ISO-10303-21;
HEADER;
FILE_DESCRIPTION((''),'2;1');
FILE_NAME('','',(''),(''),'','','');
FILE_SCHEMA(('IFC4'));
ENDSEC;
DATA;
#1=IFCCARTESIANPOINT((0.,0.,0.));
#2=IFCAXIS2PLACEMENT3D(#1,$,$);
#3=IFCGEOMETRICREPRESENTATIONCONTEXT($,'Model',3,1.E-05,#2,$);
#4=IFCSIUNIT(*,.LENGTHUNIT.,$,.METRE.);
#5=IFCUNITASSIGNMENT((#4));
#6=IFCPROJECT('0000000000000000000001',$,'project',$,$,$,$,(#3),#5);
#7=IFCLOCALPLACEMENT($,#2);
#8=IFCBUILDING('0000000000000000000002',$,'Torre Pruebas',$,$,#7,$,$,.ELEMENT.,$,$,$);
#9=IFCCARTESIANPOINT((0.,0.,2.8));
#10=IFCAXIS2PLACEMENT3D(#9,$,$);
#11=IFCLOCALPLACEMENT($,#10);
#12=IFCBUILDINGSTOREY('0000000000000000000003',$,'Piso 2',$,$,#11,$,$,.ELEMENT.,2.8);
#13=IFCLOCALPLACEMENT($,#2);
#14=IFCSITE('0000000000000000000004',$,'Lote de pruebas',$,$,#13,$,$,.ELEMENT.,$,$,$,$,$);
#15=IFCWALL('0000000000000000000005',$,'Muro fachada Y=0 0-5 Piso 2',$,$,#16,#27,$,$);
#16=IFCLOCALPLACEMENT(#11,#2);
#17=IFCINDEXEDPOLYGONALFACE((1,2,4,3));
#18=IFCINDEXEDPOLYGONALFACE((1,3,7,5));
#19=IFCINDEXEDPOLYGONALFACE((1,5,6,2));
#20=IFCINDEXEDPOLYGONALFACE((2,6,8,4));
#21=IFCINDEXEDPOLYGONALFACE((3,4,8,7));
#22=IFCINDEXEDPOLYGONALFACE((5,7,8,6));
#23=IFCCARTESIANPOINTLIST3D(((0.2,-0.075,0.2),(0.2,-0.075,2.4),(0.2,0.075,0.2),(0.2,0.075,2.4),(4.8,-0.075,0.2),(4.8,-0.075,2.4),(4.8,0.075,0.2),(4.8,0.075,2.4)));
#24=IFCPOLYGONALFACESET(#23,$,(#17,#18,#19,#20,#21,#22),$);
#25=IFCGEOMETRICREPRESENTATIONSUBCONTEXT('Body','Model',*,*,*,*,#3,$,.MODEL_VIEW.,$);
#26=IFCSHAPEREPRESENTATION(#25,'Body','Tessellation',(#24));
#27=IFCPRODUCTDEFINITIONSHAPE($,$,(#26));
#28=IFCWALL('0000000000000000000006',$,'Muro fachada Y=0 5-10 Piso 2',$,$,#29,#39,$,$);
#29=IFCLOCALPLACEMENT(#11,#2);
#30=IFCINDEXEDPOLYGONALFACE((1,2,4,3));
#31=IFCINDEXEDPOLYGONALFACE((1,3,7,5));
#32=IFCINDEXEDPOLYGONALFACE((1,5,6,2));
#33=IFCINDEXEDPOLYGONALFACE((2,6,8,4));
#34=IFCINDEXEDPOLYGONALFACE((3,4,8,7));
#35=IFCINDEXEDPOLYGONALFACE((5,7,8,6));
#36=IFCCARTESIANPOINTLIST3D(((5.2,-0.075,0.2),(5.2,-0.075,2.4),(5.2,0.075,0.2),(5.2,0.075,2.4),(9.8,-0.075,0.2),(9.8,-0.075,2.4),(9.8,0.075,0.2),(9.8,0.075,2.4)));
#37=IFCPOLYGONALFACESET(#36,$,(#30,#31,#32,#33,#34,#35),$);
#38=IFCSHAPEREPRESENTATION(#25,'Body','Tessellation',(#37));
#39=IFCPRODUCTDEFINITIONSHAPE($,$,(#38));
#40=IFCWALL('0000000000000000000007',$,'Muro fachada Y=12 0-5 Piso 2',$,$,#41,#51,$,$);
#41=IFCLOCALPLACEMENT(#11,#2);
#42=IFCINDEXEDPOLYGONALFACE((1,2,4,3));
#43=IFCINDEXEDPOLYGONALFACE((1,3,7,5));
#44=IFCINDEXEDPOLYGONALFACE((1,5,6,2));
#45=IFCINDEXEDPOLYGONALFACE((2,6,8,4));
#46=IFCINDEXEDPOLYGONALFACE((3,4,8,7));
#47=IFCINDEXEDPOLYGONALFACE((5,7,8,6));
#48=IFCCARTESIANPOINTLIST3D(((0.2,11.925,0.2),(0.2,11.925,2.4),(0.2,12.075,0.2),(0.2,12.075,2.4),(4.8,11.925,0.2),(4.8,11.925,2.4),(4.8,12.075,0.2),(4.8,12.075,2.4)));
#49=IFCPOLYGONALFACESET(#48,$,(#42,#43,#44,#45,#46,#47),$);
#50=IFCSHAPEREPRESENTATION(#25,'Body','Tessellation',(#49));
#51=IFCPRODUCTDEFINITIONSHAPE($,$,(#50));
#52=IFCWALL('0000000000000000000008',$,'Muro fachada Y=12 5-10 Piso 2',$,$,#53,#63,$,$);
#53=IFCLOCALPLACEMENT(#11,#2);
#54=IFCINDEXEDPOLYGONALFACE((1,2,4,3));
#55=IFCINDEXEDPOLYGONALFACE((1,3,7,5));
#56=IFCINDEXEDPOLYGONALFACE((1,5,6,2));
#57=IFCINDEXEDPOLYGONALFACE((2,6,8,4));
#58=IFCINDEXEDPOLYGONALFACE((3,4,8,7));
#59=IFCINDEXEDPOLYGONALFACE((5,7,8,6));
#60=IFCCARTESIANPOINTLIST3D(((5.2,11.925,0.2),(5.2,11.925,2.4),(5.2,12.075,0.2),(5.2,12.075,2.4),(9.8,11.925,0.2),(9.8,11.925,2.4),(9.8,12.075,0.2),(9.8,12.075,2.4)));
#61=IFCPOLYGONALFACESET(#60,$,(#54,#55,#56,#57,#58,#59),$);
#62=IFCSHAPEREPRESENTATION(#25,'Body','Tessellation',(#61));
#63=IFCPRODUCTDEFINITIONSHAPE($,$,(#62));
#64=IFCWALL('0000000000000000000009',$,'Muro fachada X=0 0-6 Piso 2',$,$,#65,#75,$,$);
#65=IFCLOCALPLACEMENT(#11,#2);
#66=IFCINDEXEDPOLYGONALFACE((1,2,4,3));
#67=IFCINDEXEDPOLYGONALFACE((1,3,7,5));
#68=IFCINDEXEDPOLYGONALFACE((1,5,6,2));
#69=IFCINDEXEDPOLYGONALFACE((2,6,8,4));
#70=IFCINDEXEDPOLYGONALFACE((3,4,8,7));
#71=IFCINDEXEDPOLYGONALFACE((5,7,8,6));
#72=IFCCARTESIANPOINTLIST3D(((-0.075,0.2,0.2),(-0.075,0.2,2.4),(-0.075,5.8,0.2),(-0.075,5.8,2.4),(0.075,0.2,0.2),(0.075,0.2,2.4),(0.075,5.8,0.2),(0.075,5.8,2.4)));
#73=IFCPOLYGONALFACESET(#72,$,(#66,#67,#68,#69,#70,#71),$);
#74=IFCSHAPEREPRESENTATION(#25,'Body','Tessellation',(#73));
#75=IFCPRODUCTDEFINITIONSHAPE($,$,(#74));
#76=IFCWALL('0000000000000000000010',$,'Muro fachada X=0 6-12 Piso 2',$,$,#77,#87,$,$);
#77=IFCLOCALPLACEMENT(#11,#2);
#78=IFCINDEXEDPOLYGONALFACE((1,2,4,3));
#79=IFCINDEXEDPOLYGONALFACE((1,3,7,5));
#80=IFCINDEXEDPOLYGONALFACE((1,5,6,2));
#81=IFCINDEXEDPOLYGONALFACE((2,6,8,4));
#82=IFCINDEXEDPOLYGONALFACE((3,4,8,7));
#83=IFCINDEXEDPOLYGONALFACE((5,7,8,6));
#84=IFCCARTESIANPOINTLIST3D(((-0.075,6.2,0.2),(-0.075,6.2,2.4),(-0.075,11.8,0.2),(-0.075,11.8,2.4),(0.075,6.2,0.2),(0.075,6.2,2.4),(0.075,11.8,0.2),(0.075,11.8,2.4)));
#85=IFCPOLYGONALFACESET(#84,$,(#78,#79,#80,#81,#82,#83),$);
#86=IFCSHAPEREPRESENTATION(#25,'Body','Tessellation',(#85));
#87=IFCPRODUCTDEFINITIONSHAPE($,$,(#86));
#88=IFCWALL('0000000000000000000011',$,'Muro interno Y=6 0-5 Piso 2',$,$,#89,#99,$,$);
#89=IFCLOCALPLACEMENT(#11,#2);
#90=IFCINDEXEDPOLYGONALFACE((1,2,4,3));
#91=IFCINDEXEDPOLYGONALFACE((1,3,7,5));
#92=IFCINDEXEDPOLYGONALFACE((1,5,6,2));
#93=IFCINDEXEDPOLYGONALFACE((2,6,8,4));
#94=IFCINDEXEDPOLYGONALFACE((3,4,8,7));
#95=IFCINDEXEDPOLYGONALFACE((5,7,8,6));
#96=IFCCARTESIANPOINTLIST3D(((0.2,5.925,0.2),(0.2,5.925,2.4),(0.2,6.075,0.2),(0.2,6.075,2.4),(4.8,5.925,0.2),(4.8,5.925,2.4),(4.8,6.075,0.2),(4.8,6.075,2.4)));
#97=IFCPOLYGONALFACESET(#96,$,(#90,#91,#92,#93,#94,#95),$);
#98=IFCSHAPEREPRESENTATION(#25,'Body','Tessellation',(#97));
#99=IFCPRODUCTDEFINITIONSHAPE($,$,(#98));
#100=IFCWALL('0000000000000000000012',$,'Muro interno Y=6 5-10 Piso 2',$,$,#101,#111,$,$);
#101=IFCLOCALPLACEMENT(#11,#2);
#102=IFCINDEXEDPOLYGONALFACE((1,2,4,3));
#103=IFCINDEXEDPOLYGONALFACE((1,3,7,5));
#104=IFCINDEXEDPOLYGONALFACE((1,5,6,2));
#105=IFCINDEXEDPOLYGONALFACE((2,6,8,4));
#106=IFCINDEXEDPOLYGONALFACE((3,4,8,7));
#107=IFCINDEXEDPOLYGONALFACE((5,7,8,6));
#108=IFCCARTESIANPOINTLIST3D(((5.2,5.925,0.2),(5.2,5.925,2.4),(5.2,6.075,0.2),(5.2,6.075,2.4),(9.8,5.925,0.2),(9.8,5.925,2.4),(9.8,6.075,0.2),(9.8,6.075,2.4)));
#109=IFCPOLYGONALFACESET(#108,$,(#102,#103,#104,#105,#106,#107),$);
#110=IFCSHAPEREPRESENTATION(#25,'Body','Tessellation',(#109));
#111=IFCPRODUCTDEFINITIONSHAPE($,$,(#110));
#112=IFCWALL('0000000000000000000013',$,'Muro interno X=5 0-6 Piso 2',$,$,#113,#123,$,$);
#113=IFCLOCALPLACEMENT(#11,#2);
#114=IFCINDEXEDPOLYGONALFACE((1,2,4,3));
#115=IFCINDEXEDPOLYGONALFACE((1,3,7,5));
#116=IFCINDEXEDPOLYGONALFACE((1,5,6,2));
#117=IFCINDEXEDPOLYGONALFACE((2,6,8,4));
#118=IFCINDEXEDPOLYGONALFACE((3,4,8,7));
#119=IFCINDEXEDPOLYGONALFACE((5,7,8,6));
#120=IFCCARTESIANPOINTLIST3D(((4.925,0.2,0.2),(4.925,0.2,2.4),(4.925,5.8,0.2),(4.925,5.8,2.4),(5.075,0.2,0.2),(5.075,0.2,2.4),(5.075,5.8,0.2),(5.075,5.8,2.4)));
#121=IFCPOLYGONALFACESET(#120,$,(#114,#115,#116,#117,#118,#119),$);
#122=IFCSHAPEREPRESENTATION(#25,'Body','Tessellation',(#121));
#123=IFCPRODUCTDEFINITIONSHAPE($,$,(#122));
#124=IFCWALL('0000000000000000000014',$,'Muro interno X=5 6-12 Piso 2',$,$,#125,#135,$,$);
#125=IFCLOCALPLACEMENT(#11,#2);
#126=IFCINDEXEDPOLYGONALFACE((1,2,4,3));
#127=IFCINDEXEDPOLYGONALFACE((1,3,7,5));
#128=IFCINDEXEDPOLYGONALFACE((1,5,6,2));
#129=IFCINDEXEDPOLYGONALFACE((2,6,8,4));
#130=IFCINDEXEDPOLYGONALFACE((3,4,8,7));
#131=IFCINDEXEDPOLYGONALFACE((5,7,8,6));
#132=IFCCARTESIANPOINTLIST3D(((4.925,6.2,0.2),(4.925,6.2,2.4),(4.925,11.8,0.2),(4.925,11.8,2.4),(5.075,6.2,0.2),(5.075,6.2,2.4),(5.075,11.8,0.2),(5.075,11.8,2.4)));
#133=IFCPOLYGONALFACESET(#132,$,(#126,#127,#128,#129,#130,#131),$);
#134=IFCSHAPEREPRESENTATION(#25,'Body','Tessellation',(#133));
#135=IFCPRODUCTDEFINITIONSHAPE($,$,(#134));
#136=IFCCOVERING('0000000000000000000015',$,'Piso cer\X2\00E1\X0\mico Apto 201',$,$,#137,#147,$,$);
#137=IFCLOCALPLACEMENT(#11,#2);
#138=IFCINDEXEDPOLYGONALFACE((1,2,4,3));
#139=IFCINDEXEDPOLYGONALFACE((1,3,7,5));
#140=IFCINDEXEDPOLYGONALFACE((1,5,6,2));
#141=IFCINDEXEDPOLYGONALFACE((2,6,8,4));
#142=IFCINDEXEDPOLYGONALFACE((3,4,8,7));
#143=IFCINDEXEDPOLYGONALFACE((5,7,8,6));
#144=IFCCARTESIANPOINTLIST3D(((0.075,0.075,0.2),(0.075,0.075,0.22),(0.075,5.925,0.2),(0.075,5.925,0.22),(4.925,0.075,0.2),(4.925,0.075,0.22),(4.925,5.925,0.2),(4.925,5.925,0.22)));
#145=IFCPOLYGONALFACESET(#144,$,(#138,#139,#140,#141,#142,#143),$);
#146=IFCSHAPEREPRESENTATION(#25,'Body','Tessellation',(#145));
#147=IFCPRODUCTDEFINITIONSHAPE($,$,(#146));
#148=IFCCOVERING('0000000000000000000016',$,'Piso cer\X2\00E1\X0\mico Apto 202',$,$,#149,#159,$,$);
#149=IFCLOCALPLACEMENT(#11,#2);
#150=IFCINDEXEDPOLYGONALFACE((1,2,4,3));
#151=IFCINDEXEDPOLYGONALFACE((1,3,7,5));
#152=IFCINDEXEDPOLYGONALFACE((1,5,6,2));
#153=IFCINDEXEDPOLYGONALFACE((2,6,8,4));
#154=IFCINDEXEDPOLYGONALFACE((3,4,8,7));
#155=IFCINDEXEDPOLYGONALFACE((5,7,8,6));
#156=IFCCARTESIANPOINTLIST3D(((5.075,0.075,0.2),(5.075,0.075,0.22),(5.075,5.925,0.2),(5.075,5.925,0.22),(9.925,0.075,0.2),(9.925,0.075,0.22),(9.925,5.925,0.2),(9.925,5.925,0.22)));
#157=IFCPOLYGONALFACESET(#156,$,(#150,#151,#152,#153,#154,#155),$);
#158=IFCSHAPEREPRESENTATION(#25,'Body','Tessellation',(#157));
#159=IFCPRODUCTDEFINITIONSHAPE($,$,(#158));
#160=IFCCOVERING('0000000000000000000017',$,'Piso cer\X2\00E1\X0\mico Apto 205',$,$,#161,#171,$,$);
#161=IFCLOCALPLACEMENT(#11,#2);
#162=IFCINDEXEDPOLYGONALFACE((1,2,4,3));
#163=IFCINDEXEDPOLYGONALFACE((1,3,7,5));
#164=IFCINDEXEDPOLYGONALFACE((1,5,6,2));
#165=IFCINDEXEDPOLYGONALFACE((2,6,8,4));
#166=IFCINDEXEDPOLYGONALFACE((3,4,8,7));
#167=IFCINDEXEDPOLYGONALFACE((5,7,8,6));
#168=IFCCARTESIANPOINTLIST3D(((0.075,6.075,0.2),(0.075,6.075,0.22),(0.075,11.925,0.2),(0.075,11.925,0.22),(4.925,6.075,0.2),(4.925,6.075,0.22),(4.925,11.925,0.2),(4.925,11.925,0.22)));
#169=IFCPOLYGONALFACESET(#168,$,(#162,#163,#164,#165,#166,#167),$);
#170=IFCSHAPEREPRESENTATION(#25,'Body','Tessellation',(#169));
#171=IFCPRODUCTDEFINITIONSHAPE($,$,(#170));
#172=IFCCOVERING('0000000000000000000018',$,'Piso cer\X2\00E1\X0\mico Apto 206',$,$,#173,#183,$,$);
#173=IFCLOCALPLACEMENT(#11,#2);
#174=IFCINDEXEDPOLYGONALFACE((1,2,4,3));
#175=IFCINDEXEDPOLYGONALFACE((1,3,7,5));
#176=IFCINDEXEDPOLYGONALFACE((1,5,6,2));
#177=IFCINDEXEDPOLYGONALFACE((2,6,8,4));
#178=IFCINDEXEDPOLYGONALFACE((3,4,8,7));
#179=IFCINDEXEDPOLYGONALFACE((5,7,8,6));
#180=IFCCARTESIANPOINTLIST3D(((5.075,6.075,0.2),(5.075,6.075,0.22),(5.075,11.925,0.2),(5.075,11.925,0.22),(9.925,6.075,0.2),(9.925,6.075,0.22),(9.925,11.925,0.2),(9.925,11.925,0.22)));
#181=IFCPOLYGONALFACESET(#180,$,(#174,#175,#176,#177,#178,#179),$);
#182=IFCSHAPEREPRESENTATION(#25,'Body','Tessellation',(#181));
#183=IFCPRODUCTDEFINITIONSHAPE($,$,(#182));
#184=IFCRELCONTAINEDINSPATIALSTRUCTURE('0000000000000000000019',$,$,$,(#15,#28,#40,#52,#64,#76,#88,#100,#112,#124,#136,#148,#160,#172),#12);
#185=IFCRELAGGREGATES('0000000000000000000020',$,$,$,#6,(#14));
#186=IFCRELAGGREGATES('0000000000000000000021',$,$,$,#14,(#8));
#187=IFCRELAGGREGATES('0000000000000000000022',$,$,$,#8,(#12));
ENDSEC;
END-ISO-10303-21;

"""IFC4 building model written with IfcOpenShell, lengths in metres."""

from ifc_helpers import new_model, si_unit, frame, origin, origin_2d, place, context, subcontext, project, spatial, rectangle, extrude, element, save


model = new_model("IFC4")

# Units and contexts
model_context = context("Model", 3, precision=1e-05, world=origin())
body_context = subcontext(model_context, "Body", "Model", "MODEL_VIEW")
ifc_project = project(units=[si_unit("LENGTHUNIT", "METRE")], contexts=[model_context])

# Site, building, storey
site_placement = place(None, origin())
site = spatial("IfcSite", under=ifc_project, at=site_placement, Name="Lote de pruebas", CompositionType="ELEMENT")
building_placement = place(None, origin())
building = spatial("IfcBuilding", under=site, at=building_placement, Name="Torre Pruebas", CompositionType="ELEMENT")
storey_placement = place(None, frame((0.0, 0.0, 2.8)))
storey = spatial("IfcBuildingStorey", under=building, at=storey_placement, Name="Piso 2", CompositionType="ELEMENT", Elevation=2.8)

# Walls
for number, where, name in (
    (1, (2.5, 0.0, 3.0), "Muro fachada Y=0 0-5 Piso 2"),
    (2, (7.5, 0.0, 3.0), "Muro fachada Y=0 5-10 Piso 2"),
    (3, (2.5, 12.0, 3.0), "Muro fachada Y=12 0-5 Piso 2"),
    (4, (7.5, 12.0, 3.0), "Muro fachada Y=12 5-10 Piso 2"),
):
    element("IfcWall", number, at=place(None, frame(where)), inside=storey, Name=name, context=body_context, shape_type="SweptSolid", body=[
        extrude(rectangle(XDim=4.6, YDim=0.15, at=origin_2d()), origin(), (0.0, 0.0, 1.0), 2.2),
    ])
for number, where, name in (
    (5, (0.0, 3.0, 3.0), "Muro fachada X=0 0-6 Piso 2"),
    (6, (0.0, 9.0, 3.0), "Muro fachada X=0 6-12 Piso 2"),
):
    element("IfcWall", number, at=place(None, frame(where)), inside=storey, Name=name, context=body_context, shape_type="SweptSolid", body=[
        extrude(rectangle(XDim=0.15, YDim=5.6, at=origin_2d()), origin(), (0.0, 0.0, 1.0), 2.2),
    ])
for number, where, name in (
    (7, (2.5, 6.0, 3.0), "Muro interno Y=6 0-5 Piso 2"),
    (8, (7.5, 6.0, 3.0), "Muro interno Y=6 5-10 Piso 2"),
):
    element("IfcWall", number, at=place(None, frame(where)), inside=storey, Name=name, context=body_context, shape_type="SweptSolid", body=[
        extrude(rectangle(XDim=4.6, YDim=0.15, at=origin_2d()), origin(), (0.0, 0.0, 1.0), 2.2),
    ])
for number, where, name in (
    (9, (5.0, 3.0, 3.0), "Muro interno X=5 0-6 Piso 2"),
    (10, (5.0, 9.0, 3.0), "Muro interno X=5 6-12 Piso 2"),
):
    element("IfcWall", number, at=place(None, frame(where)), inside=storey, Name=name, context=body_context, shape_type="SweptSolid", body=[
        extrude(rectangle(XDim=0.15, YDim=5.6, at=origin_2d()), origin(), (0.0, 0.0, 1.0), 2.2),
    ])

# Coverings
for number, where, name in (
    (11, (2.5, 3.0, 3.0), "Piso cerámico Apto 201"),
    (12, (7.5, 3.0, 3.0), "Piso cerámico Apto 202"),
    (13, (2.5, 9.0, 3.0), "Piso cerámico Apto 205"),
    (14, (7.5, 9.0, 3.0), "Piso cerámico Apto 206"),
):
    element("IfcCovering", number, at=place(None, frame(where)), inside=storey, Name=name, context=body_context, shape_type="SweptSolid", body=[
        extrude(rectangle(XDim=4.85, YDim=5.85, at=origin_2d()), origin(), (0.0, 0.0, 1.0), 0.02),
    ])

save(model, "model.ifc")
